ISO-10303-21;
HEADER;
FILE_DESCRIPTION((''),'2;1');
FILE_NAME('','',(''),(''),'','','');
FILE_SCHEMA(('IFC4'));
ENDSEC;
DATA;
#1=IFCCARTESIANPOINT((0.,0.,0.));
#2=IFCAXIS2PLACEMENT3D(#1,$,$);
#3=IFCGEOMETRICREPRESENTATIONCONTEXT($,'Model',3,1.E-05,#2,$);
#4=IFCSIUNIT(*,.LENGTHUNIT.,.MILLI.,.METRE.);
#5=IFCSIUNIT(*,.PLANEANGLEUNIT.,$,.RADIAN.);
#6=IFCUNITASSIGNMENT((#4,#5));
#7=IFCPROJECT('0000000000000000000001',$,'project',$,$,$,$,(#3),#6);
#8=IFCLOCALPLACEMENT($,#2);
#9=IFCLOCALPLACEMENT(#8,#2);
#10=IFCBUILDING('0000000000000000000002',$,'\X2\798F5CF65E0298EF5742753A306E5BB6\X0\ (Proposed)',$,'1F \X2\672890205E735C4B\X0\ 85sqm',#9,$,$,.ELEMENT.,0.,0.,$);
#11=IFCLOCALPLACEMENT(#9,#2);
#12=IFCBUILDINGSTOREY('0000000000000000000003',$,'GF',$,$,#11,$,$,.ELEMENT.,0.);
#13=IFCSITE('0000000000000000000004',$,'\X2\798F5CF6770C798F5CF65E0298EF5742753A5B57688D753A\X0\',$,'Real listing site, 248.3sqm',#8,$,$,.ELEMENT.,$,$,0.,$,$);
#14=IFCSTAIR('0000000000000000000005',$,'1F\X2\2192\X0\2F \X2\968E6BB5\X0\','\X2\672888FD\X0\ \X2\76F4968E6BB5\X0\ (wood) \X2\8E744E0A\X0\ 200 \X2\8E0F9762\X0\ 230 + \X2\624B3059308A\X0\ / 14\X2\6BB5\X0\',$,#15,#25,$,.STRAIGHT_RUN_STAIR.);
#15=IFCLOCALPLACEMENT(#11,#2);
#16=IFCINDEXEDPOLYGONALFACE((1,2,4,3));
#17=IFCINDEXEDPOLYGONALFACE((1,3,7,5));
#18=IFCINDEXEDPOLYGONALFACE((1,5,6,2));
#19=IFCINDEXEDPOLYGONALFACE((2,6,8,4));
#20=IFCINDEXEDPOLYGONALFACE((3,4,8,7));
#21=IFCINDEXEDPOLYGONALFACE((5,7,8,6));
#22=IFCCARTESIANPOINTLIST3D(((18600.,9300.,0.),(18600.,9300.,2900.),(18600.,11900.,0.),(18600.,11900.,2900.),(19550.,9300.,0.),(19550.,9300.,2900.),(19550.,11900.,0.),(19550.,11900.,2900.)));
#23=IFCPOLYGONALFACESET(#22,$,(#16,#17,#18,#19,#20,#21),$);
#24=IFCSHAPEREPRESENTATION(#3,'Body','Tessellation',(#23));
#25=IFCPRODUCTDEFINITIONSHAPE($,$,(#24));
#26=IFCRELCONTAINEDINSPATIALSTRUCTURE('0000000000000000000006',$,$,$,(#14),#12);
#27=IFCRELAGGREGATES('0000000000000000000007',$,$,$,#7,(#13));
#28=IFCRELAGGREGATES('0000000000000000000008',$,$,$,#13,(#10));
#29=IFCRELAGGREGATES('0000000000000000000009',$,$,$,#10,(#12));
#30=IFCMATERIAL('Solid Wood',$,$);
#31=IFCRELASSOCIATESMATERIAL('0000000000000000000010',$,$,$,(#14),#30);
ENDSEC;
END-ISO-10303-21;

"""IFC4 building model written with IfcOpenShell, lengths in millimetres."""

from ifc_helpers import new_model, si_unit, frame, frame_2d, origin, place, context, project, spatial, rectangle, extrude, material, element, save


model = new_model("IFC4")

# Units and contexts
model_context = context("Model", 3, precision=1e-05, world=origin())
ifc_project = project(units=[si_unit("LENGTHUNIT", "METRE", prefix="MILLI"), si_unit("PLANEANGLEUNIT", "RADIAN")], contexts=[model_context])

# Site, building, storey
site_placement = place(None, origin())
site = spatial("IfcSite", under=ifc_project, at=site_placement, Name="福島県福島市飯坂町字梍町", ObjectType="Real listing site, 248.3sqm", CompositionType="ELEMENT", RefElevation=0.0)
building_placement = place(site_placement, origin())
building = spatial("IfcBuilding", under=site, at=building_placement, Name="福島市飯坂町の家 (Proposed)", ObjectType="1F 木造平屋 85sqm", CompositionType="ELEMENT", ElevationOfRefHeight=0.0, ElevationOfTerrain=0.0)
storey_placement = place(building_placement, origin())
storey = spatial("IfcBuildingStorey", under=building, at=storey_placement, Name="GF", CompositionType="ELEMENT", Elevation=0.0)

# Shared definitions
ifc_material_1 = material(Name="Solid Wood")

# Stair
stair_placement = place(storey_placement, frame((9300.0, 4650.0, 0.0)))
element("IfcStair", 1, at=stair_placement, inside=storey, material=ifc_material_1, Name="1F→2F 階段", Description="木製 直階段 (wood) 蹴上 200 踏面 230 + 手すり / 14段", PredefinedType="STRAIGHT_RUN_STAIR", context=model_context, shape_type="SweptSolid", body=[
    extrude(rectangle(XDim=950.0, YDim=2600.0, at=frame_2d((475.0, 1300.0))), frame((9300.0, 4650.0, 0.0)), (0.0, 0.0, 1.0), 2900.0),
])

save(model, "model.ifc")
